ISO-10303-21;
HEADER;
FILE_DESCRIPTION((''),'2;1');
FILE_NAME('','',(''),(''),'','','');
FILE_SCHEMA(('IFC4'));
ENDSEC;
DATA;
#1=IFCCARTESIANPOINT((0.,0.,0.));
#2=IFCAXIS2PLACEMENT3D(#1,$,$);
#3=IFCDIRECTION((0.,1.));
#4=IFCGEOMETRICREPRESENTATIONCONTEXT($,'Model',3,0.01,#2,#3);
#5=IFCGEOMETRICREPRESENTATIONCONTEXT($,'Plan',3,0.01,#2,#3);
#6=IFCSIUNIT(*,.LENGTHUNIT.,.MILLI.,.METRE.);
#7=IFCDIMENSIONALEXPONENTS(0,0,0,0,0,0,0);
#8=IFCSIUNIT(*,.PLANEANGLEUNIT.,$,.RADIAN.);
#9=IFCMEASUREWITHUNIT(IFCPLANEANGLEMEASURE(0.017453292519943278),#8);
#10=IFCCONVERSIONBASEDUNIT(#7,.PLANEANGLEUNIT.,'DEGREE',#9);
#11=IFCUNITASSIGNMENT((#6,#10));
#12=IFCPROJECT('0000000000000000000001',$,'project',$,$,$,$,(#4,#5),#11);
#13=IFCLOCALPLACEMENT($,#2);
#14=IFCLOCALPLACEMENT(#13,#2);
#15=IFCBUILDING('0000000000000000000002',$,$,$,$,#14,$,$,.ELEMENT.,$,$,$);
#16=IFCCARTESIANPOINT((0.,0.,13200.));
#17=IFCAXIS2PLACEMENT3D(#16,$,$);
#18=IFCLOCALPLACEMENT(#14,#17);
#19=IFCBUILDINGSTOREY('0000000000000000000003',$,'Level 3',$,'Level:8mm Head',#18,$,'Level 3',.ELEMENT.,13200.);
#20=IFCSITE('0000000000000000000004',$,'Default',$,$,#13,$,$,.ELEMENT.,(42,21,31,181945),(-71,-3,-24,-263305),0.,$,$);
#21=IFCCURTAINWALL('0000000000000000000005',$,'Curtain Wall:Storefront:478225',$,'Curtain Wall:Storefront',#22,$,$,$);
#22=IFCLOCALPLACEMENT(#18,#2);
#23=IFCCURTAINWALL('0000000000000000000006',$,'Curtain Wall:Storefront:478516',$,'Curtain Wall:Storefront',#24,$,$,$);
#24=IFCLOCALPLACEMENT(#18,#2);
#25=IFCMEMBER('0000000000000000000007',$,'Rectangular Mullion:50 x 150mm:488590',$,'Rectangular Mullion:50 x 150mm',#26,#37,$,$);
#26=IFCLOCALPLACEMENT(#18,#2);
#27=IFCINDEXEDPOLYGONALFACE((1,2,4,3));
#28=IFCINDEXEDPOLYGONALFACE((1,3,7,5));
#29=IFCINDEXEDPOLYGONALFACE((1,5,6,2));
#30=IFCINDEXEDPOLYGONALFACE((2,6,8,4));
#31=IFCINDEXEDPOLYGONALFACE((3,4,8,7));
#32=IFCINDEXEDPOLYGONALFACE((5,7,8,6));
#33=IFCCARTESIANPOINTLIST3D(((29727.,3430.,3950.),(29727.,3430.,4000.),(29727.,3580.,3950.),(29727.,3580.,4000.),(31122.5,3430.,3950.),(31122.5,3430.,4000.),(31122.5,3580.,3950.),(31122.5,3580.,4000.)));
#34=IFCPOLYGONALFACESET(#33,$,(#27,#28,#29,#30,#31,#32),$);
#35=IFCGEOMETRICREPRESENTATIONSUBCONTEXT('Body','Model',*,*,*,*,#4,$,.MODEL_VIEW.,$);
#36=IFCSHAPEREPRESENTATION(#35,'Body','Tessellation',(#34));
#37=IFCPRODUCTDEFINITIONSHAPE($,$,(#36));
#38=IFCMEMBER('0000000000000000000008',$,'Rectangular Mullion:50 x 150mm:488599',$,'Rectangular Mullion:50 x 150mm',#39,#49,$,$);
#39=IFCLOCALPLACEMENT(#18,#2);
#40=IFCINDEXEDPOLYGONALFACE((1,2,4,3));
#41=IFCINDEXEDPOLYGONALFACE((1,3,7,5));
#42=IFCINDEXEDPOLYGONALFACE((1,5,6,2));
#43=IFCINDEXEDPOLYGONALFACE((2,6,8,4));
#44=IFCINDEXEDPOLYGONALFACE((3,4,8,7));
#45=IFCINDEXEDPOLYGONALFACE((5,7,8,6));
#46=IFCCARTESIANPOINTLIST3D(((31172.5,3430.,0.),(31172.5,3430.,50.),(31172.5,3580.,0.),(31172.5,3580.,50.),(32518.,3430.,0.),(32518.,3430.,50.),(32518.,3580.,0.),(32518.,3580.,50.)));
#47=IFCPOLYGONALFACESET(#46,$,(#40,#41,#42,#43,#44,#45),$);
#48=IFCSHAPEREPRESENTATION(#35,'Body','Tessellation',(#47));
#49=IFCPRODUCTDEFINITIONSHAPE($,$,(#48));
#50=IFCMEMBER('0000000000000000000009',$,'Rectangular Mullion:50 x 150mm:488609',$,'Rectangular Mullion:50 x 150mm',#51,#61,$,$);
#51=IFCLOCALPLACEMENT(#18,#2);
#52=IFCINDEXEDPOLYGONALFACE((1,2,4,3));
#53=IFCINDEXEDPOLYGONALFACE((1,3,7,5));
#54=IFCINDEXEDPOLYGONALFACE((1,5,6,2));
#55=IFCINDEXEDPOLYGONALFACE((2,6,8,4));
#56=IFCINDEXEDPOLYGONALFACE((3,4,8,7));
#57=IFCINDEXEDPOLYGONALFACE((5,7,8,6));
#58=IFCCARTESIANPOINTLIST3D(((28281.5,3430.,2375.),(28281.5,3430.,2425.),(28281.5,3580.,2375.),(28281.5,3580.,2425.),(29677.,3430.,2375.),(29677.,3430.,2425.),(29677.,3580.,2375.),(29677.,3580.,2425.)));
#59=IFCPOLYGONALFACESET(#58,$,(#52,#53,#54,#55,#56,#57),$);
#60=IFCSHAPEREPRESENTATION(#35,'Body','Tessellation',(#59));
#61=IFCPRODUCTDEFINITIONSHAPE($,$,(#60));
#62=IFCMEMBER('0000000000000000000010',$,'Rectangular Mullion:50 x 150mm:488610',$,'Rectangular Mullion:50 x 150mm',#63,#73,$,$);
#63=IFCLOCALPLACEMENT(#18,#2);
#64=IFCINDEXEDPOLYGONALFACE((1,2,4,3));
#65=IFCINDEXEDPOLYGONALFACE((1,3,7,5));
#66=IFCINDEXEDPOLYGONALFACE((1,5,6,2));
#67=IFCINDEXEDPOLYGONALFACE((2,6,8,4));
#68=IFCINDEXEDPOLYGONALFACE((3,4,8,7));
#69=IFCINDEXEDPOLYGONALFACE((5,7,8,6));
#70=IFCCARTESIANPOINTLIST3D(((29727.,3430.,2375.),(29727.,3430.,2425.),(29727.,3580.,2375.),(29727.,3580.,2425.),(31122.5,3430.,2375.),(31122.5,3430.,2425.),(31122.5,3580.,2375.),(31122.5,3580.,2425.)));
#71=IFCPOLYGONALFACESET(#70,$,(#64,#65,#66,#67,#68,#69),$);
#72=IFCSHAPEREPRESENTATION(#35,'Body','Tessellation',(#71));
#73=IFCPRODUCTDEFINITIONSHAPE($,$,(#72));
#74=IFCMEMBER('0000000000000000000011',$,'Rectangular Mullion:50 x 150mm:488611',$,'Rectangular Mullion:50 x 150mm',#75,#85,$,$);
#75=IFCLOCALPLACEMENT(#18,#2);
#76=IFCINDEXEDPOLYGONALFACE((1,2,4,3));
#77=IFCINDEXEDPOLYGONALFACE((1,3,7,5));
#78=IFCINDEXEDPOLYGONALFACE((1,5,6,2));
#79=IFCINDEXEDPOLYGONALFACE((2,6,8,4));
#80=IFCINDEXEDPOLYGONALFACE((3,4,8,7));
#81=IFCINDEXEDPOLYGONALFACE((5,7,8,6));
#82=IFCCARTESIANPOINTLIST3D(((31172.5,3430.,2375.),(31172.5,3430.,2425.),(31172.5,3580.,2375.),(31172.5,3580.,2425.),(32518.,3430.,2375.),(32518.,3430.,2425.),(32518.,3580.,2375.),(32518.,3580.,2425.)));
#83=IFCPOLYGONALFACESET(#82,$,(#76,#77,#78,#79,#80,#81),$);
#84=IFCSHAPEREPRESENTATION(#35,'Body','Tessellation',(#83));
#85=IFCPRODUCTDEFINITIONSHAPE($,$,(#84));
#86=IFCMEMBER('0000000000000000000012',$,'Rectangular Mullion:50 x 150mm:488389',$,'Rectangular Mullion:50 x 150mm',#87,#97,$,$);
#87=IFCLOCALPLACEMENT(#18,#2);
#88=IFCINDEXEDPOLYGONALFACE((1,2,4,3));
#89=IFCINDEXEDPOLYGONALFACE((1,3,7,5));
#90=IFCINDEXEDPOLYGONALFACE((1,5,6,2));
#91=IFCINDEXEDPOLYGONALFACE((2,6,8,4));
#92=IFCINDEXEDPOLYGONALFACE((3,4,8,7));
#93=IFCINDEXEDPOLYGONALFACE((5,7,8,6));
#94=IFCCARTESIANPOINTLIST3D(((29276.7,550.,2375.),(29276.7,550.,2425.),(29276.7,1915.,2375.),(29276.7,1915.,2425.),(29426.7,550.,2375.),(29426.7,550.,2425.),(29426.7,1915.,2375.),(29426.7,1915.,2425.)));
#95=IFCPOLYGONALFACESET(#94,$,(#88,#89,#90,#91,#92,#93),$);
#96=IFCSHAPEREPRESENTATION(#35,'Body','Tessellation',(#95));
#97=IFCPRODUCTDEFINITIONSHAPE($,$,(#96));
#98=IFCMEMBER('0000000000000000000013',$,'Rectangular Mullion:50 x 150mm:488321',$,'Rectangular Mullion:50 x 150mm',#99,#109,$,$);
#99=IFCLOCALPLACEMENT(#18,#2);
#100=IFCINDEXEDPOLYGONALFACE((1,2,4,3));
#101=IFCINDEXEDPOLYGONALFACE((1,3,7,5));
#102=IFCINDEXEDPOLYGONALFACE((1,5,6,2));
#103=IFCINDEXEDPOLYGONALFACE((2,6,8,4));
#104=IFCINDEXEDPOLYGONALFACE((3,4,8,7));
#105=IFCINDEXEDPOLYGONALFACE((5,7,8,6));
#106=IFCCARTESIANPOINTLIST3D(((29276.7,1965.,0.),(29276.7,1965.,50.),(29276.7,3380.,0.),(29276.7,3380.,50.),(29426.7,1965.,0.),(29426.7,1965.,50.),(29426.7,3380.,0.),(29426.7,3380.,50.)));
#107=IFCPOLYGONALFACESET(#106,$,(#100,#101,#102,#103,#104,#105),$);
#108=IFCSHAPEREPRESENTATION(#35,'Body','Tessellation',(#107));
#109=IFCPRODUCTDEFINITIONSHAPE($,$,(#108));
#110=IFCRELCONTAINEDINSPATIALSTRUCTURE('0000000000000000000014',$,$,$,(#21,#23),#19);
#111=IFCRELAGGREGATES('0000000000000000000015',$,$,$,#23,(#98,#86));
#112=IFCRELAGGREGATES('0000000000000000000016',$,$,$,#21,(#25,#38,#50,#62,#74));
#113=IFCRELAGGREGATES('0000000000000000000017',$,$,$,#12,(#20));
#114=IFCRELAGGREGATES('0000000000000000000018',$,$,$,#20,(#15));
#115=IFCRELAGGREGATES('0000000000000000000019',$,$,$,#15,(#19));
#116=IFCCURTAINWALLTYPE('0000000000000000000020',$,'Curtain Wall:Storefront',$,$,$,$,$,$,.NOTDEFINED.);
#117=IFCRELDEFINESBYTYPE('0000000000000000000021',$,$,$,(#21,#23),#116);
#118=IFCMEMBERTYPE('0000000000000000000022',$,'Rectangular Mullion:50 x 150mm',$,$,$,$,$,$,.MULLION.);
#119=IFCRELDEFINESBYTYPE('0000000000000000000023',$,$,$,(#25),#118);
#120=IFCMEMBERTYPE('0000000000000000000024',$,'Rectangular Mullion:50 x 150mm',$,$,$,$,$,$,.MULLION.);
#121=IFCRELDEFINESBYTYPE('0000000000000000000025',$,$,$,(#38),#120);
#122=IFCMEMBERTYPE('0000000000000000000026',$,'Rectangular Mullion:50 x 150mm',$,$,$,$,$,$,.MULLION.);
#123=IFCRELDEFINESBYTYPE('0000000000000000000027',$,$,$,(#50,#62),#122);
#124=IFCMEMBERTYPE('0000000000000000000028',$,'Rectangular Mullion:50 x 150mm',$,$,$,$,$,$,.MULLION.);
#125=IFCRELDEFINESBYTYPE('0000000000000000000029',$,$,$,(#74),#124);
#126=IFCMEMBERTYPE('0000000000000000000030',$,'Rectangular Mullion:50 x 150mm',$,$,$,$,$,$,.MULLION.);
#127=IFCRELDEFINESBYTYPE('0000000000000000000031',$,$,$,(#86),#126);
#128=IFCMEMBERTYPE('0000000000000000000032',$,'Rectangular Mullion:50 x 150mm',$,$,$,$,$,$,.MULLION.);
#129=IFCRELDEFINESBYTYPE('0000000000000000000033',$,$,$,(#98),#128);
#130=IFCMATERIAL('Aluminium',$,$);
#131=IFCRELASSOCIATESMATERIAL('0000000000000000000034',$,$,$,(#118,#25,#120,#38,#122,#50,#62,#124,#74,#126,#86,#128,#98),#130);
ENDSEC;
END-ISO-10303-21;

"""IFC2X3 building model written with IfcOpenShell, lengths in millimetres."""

from ifc_helpers import new_model, entity, si_unit, converted_unit, direction, frame, origin, origin_2d_with_axis, place, context, subcontext, project, spatial, rectangle, extrude, source, transform, mapped, material, type_object, type_shapes, element, aggregate, save


model = new_model("IFC2X3")

# Units and contexts
model_context = context("Model", 3, precision=0.01, world=origin(), true_north=direction((0.0, 1.0)))
plan_context = context("Plan", 3, precision=0.01, world=origin(), true_north=direction((0.0, 1.0)))
body_context = subcontext(model_context, "Body", "Model", "MODEL_VIEW")
ifc_project = project(units=[si_unit("LENGTHUNIT", "METRE", prefix="MILLI"), converted_unit("PLANEANGLEUNIT", "DEGREE", entity("IfcPlaneAngleMeasure", 0.017453292519943278), si_unit("PLANEANGLEUNIT", "RADIAN"), dimensions=[0, 0, 0, 0, 0, 0, 0])], contexts=[model_context, plan_context])

# Site, building, storey
site_placement = place(None, origin())
site = spatial("IfcSite", under=ifc_project, at=site_placement, Name="Default", CompositionType="ELEMENT", RefLatitude=(42, 21, 31, 181945), RefLongitude=(-71, -3, -24, -263305), RefElevation=0.0)
building_placement = place(site_placement, origin())
building = spatial("IfcBuilding", under=site, at=building_placement, CompositionType="ELEMENT")
storey_placement = place(building_placement, frame((0.0, 0.0, 13200.0)))
storey = spatial("IfcBuildingStorey", under=building, at=storey_placement, Name="Level 3", ObjectType="Level:8mm Head", LongName="Level 3", CompositionType="ELEMENT", Elevation=13200.0)

# Curtain walls
curtain_wall_type = type_object("IfcCurtainWallType", Name="Curtain Wall:Storefront", PredefinedType="NOTDEFINED")
curtain_wall_1_placement = place(storey_placement, frame((0.0, 0.0, -13200.0)))
curtain_wall_1 = element("IfcCurtainWall", 1, at=curtain_wall_1_placement, inside=storey, type_object=curtain_wall_type, Name="Curtain Wall:Storefront:478225", ObjectType="Curtain Wall:Storefront")
ifc_material_1 = material(Name="Aluminium")
curtain_wall_2_placement = place(storey_placement, frame((0.0, 0.0, -13200.0)))
curtain_wall_2 = element("IfcCurtainWall", 2, at=curtain_wall_2_placement, inside=storey, type_object=curtain_wall_type, Name="Curtain Wall:Storefront:478516", ObjectType="Curtain Wall:Storefront")

# Members
member_type_1 = type_object("IfcMemberType", Name="Rectangular Mullion:50 x 150mm", PredefinedType="MULLION", material=ifc_material_1)
shared_shape_1 = source(origin(), body_context, "Body", "SweptSolid", [
    extrude(rectangle(XDim=50.0, YDim=150.0, at=origin_2d_with_axis()), frame((-25.0, 0.0, -1395.5), z_axis=(0.0, 0.0, 1.0), x_axis=(-1.0, 0.0, 0.0)), (0.0, 0.0, 1.0), 1395.5),
])
type_shapes(member_type_1, [shared_shape_1])
member_1_placement = place(curtain_wall_1_placement, frame((31122.5, 3505.0, 17200.0), z_axis=(1.0, 0.0, 0.0), x_axis=(0.0, 0.0, 1.0)))
member_1 = element("IfcMember", 3, at=member_1_placement, type_object=member_type_1, material=ifc_material_1, Name="Rectangular Mullion:50 x 150mm:488590", ObjectType="Rectangular Mullion:50 x 150mm", context=body_context, shape_type="MappedRepresentation", body=[
    mapped(shared_shape_1, transform((0.0, 0.0, 0.0), scale=1.0)),
])
member_type_2 = type_object("IfcMemberType", Name="Rectangular Mullion:50 x 150mm", PredefinedType="MULLION", material=ifc_material_1)
shared_shape_2 = source(origin(), body_context, "Body", "SweptSolid", [
    extrude(rectangle(XDim=50.0, YDim=150.0, at=origin_2d_with_axis()), frame((-25.0, 0.0, -1345.5), z_axis=(0.0, 0.0, 1.0), x_axis=(-1.0, 0.0, 0.0)), (0.0, 0.0, 1.0), 1345.5),
])
type_shapes(member_type_2, [shared_shape_2])
member_2_placement = place(curtain_wall_1_placement, frame((31172.5, 3505.0, 13200.0), z_axis=(-1.0, 0.0, 0.0), x_axis=(0.0, 0.0, -1.0)))
member_2 = element("IfcMember", 4, at=member_2_placement, type_object=member_type_2, material=ifc_material_1, Name="Rectangular Mullion:50 x 150mm:488599", ObjectType="Rectangular Mullion:50 x 150mm", context=body_context, shape_type="MappedRepresentation", body=[
    mapped(shared_shape_2, transform((0.0, 0.0, 0.0), scale=1.0)),
])
member_type_3 = type_object("IfcMemberType", Name="Rectangular Mullion:50 x 150mm", PredefinedType="MULLION", material=ifc_material_1)
shared_shape_3 = source(origin(), body_context, "Body", "SweptSolid", [
    extrude(rectangle(XDim=50.0, YDim=150.0, at=origin_2d_with_axis()), frame((0.0, 0.0, -1395.5), z_axis=(0.0, 0.0, 1.0), x_axis=(-1.0, 0.0, 0.0)), (0.0, 0.0, 1.0), 1395.5),
])
type_shapes(member_type_3, [shared_shape_3])
member_3_placement = place(curtain_wall_1_placement, frame((29677.0, 3505.0, 15600.0), z_axis=(1.0, 0.0, 0.0), x_axis=(0.0, 0.0, 1.0)))
member_3 = element("IfcMember", 5, at=member_3_placement, type_object=member_type_3, material=ifc_material_1, Name="Rectangular Mullion:50 x 150mm:488609", ObjectType="Rectangular Mullion:50 x 150mm", context=body_context, shape_type="MappedRepresentation", body=[
    mapped(shared_shape_3, transform((0.0, 0.0, 0.0), scale=1.0)),
])
member_4_placement = place(curtain_wall_1_placement, frame((31122.5, 3505.0, 15600.0), z_axis=(1.0, 0.0, 0.0), x_axis=(0.0, 0.0, 1.0)))
member_4 = element("IfcMember", 6, at=member_4_placement, type_object=member_type_3, material=ifc_material_1, Name="Rectangular Mullion:50 x 150mm:488610", ObjectType="Rectangular Mullion:50 x 150mm", context=body_context, shape_type="MappedRepresentation", body=[
    mapped(shared_shape_3, transform((0.0, 0.0, 0.0), scale=1.0)),
])
member_type_4 = type_object("IfcMemberType", Name="Rectangular Mullion:50 x 150mm", PredefinedType="MULLION", material=ifc_material_1)
shared_shape_4 = source(origin(), body_context, "Body", "SweptSolid", [
    extrude(rectangle(XDim=50.0, YDim=150.0, at=origin_2d_with_axis()), frame((0.0, 0.0, -1345.5), z_axis=(0.0, 0.0, 1.0), x_axis=(-1.0, 0.0, 0.0)), (0.0, 0.0, 1.0), 1345.5),
])
type_shapes(member_type_4, [shared_shape_4])
member_5_placement = place(curtain_wall_1_placement, frame((32518.0, 3505.0, 15600.0), z_axis=(1.0, 0.0, 0.0), x_axis=(0.0, 0.0, 1.0)))
member_5 = element("IfcMember", 7, at=member_5_placement, type_object=member_type_4, material=ifc_material_1, Name="Rectangular Mullion:50 x 150mm:488611", ObjectType="Rectangular Mullion:50 x 150mm", context=body_context, shape_type="MappedRepresentation", body=[
    mapped(shared_shape_4, transform((0.0, 0.0, 0.0), scale=1.0)),
])
member_type_5 = type_object("IfcMemberType", Name="Rectangular Mullion:50 x 150mm", PredefinedType="MULLION", material=ifc_material_1)
shared_shape_5 = source(origin(), body_context, "Body", "SweptSolid", [
    extrude(rectangle(XDim=50.0, YDim=150.0, at=origin_2d_with_axis()), frame((0.0, 0.0, -1365.0), z_axis=(0.0, 0.0, 1.0), x_axis=(-1.0, 0.0, 0.0)), (0.0, 0.0, 1.0), 1365.0),
])
type_shapes(member_type_5, [shared_shape_5])
member_6_placement = place(curtain_wall_2_placement, frame((29351.7, 550.0, 15600.0), z_axis=(0.0, -1.0, 0.0), x_axis=(0.0, 0.0, 1.0)))
member_6 = element("IfcMember", 8, at=member_6_placement, type_object=member_type_5, material=ifc_material_1, Name="Rectangular Mullion:50 x 150mm:488389", ObjectType="Rectangular Mullion:50 x 150mm", context=body_context, shape_type="MappedRepresentation", body=[
    mapped(shared_shape_5, transform((0.0, 0.0, 0.0), scale=1.0)),
])
member_type_6 = type_object("IfcMemberType", Name="Rectangular Mullion:50 x 150mm", PredefinedType="MULLION", material=ifc_material_1)
shared_shape_6 = source(origin(), body_context, "Body", "SweptSolid", [
    extrude(rectangle(XDim=50.0, YDim=150.0, at=origin_2d_with_axis()), frame((-25.0, 0.0, -1415.0), z_axis=(0.0, 0.0, 1.0), x_axis=(-1.0, 0.0, 0.0)), (0.0, 0.0, 1.0), 1415.0),
])
type_shapes(member_type_6, [shared_shape_6])
member_7_placement = place(curtain_wall_2_placement, frame((29351.7, 3380.0, 13200.0), z_axis=(0.0, 1.0, 0.0), x_axis=(0.0, 0.0, -1.0)))
member_7 = element("IfcMember", 9, at=member_7_placement, type_object=member_type_6, material=ifc_material_1, Name="Rectangular Mullion:50 x 150mm:488321", ObjectType="Rectangular Mullion:50 x 150mm", context=body_context, shape_type="MappedRepresentation", body=[
    mapped(shared_shape_6, transform((0.0, 0.0, 0.0), scale=1.0)),
])

aggregate(curtain_wall_2, [member_7, member_6])

aggregate(curtain_wall_1, [member_1, member_2, member_3, member_4, member_5])

save(model, "model.ifc")
